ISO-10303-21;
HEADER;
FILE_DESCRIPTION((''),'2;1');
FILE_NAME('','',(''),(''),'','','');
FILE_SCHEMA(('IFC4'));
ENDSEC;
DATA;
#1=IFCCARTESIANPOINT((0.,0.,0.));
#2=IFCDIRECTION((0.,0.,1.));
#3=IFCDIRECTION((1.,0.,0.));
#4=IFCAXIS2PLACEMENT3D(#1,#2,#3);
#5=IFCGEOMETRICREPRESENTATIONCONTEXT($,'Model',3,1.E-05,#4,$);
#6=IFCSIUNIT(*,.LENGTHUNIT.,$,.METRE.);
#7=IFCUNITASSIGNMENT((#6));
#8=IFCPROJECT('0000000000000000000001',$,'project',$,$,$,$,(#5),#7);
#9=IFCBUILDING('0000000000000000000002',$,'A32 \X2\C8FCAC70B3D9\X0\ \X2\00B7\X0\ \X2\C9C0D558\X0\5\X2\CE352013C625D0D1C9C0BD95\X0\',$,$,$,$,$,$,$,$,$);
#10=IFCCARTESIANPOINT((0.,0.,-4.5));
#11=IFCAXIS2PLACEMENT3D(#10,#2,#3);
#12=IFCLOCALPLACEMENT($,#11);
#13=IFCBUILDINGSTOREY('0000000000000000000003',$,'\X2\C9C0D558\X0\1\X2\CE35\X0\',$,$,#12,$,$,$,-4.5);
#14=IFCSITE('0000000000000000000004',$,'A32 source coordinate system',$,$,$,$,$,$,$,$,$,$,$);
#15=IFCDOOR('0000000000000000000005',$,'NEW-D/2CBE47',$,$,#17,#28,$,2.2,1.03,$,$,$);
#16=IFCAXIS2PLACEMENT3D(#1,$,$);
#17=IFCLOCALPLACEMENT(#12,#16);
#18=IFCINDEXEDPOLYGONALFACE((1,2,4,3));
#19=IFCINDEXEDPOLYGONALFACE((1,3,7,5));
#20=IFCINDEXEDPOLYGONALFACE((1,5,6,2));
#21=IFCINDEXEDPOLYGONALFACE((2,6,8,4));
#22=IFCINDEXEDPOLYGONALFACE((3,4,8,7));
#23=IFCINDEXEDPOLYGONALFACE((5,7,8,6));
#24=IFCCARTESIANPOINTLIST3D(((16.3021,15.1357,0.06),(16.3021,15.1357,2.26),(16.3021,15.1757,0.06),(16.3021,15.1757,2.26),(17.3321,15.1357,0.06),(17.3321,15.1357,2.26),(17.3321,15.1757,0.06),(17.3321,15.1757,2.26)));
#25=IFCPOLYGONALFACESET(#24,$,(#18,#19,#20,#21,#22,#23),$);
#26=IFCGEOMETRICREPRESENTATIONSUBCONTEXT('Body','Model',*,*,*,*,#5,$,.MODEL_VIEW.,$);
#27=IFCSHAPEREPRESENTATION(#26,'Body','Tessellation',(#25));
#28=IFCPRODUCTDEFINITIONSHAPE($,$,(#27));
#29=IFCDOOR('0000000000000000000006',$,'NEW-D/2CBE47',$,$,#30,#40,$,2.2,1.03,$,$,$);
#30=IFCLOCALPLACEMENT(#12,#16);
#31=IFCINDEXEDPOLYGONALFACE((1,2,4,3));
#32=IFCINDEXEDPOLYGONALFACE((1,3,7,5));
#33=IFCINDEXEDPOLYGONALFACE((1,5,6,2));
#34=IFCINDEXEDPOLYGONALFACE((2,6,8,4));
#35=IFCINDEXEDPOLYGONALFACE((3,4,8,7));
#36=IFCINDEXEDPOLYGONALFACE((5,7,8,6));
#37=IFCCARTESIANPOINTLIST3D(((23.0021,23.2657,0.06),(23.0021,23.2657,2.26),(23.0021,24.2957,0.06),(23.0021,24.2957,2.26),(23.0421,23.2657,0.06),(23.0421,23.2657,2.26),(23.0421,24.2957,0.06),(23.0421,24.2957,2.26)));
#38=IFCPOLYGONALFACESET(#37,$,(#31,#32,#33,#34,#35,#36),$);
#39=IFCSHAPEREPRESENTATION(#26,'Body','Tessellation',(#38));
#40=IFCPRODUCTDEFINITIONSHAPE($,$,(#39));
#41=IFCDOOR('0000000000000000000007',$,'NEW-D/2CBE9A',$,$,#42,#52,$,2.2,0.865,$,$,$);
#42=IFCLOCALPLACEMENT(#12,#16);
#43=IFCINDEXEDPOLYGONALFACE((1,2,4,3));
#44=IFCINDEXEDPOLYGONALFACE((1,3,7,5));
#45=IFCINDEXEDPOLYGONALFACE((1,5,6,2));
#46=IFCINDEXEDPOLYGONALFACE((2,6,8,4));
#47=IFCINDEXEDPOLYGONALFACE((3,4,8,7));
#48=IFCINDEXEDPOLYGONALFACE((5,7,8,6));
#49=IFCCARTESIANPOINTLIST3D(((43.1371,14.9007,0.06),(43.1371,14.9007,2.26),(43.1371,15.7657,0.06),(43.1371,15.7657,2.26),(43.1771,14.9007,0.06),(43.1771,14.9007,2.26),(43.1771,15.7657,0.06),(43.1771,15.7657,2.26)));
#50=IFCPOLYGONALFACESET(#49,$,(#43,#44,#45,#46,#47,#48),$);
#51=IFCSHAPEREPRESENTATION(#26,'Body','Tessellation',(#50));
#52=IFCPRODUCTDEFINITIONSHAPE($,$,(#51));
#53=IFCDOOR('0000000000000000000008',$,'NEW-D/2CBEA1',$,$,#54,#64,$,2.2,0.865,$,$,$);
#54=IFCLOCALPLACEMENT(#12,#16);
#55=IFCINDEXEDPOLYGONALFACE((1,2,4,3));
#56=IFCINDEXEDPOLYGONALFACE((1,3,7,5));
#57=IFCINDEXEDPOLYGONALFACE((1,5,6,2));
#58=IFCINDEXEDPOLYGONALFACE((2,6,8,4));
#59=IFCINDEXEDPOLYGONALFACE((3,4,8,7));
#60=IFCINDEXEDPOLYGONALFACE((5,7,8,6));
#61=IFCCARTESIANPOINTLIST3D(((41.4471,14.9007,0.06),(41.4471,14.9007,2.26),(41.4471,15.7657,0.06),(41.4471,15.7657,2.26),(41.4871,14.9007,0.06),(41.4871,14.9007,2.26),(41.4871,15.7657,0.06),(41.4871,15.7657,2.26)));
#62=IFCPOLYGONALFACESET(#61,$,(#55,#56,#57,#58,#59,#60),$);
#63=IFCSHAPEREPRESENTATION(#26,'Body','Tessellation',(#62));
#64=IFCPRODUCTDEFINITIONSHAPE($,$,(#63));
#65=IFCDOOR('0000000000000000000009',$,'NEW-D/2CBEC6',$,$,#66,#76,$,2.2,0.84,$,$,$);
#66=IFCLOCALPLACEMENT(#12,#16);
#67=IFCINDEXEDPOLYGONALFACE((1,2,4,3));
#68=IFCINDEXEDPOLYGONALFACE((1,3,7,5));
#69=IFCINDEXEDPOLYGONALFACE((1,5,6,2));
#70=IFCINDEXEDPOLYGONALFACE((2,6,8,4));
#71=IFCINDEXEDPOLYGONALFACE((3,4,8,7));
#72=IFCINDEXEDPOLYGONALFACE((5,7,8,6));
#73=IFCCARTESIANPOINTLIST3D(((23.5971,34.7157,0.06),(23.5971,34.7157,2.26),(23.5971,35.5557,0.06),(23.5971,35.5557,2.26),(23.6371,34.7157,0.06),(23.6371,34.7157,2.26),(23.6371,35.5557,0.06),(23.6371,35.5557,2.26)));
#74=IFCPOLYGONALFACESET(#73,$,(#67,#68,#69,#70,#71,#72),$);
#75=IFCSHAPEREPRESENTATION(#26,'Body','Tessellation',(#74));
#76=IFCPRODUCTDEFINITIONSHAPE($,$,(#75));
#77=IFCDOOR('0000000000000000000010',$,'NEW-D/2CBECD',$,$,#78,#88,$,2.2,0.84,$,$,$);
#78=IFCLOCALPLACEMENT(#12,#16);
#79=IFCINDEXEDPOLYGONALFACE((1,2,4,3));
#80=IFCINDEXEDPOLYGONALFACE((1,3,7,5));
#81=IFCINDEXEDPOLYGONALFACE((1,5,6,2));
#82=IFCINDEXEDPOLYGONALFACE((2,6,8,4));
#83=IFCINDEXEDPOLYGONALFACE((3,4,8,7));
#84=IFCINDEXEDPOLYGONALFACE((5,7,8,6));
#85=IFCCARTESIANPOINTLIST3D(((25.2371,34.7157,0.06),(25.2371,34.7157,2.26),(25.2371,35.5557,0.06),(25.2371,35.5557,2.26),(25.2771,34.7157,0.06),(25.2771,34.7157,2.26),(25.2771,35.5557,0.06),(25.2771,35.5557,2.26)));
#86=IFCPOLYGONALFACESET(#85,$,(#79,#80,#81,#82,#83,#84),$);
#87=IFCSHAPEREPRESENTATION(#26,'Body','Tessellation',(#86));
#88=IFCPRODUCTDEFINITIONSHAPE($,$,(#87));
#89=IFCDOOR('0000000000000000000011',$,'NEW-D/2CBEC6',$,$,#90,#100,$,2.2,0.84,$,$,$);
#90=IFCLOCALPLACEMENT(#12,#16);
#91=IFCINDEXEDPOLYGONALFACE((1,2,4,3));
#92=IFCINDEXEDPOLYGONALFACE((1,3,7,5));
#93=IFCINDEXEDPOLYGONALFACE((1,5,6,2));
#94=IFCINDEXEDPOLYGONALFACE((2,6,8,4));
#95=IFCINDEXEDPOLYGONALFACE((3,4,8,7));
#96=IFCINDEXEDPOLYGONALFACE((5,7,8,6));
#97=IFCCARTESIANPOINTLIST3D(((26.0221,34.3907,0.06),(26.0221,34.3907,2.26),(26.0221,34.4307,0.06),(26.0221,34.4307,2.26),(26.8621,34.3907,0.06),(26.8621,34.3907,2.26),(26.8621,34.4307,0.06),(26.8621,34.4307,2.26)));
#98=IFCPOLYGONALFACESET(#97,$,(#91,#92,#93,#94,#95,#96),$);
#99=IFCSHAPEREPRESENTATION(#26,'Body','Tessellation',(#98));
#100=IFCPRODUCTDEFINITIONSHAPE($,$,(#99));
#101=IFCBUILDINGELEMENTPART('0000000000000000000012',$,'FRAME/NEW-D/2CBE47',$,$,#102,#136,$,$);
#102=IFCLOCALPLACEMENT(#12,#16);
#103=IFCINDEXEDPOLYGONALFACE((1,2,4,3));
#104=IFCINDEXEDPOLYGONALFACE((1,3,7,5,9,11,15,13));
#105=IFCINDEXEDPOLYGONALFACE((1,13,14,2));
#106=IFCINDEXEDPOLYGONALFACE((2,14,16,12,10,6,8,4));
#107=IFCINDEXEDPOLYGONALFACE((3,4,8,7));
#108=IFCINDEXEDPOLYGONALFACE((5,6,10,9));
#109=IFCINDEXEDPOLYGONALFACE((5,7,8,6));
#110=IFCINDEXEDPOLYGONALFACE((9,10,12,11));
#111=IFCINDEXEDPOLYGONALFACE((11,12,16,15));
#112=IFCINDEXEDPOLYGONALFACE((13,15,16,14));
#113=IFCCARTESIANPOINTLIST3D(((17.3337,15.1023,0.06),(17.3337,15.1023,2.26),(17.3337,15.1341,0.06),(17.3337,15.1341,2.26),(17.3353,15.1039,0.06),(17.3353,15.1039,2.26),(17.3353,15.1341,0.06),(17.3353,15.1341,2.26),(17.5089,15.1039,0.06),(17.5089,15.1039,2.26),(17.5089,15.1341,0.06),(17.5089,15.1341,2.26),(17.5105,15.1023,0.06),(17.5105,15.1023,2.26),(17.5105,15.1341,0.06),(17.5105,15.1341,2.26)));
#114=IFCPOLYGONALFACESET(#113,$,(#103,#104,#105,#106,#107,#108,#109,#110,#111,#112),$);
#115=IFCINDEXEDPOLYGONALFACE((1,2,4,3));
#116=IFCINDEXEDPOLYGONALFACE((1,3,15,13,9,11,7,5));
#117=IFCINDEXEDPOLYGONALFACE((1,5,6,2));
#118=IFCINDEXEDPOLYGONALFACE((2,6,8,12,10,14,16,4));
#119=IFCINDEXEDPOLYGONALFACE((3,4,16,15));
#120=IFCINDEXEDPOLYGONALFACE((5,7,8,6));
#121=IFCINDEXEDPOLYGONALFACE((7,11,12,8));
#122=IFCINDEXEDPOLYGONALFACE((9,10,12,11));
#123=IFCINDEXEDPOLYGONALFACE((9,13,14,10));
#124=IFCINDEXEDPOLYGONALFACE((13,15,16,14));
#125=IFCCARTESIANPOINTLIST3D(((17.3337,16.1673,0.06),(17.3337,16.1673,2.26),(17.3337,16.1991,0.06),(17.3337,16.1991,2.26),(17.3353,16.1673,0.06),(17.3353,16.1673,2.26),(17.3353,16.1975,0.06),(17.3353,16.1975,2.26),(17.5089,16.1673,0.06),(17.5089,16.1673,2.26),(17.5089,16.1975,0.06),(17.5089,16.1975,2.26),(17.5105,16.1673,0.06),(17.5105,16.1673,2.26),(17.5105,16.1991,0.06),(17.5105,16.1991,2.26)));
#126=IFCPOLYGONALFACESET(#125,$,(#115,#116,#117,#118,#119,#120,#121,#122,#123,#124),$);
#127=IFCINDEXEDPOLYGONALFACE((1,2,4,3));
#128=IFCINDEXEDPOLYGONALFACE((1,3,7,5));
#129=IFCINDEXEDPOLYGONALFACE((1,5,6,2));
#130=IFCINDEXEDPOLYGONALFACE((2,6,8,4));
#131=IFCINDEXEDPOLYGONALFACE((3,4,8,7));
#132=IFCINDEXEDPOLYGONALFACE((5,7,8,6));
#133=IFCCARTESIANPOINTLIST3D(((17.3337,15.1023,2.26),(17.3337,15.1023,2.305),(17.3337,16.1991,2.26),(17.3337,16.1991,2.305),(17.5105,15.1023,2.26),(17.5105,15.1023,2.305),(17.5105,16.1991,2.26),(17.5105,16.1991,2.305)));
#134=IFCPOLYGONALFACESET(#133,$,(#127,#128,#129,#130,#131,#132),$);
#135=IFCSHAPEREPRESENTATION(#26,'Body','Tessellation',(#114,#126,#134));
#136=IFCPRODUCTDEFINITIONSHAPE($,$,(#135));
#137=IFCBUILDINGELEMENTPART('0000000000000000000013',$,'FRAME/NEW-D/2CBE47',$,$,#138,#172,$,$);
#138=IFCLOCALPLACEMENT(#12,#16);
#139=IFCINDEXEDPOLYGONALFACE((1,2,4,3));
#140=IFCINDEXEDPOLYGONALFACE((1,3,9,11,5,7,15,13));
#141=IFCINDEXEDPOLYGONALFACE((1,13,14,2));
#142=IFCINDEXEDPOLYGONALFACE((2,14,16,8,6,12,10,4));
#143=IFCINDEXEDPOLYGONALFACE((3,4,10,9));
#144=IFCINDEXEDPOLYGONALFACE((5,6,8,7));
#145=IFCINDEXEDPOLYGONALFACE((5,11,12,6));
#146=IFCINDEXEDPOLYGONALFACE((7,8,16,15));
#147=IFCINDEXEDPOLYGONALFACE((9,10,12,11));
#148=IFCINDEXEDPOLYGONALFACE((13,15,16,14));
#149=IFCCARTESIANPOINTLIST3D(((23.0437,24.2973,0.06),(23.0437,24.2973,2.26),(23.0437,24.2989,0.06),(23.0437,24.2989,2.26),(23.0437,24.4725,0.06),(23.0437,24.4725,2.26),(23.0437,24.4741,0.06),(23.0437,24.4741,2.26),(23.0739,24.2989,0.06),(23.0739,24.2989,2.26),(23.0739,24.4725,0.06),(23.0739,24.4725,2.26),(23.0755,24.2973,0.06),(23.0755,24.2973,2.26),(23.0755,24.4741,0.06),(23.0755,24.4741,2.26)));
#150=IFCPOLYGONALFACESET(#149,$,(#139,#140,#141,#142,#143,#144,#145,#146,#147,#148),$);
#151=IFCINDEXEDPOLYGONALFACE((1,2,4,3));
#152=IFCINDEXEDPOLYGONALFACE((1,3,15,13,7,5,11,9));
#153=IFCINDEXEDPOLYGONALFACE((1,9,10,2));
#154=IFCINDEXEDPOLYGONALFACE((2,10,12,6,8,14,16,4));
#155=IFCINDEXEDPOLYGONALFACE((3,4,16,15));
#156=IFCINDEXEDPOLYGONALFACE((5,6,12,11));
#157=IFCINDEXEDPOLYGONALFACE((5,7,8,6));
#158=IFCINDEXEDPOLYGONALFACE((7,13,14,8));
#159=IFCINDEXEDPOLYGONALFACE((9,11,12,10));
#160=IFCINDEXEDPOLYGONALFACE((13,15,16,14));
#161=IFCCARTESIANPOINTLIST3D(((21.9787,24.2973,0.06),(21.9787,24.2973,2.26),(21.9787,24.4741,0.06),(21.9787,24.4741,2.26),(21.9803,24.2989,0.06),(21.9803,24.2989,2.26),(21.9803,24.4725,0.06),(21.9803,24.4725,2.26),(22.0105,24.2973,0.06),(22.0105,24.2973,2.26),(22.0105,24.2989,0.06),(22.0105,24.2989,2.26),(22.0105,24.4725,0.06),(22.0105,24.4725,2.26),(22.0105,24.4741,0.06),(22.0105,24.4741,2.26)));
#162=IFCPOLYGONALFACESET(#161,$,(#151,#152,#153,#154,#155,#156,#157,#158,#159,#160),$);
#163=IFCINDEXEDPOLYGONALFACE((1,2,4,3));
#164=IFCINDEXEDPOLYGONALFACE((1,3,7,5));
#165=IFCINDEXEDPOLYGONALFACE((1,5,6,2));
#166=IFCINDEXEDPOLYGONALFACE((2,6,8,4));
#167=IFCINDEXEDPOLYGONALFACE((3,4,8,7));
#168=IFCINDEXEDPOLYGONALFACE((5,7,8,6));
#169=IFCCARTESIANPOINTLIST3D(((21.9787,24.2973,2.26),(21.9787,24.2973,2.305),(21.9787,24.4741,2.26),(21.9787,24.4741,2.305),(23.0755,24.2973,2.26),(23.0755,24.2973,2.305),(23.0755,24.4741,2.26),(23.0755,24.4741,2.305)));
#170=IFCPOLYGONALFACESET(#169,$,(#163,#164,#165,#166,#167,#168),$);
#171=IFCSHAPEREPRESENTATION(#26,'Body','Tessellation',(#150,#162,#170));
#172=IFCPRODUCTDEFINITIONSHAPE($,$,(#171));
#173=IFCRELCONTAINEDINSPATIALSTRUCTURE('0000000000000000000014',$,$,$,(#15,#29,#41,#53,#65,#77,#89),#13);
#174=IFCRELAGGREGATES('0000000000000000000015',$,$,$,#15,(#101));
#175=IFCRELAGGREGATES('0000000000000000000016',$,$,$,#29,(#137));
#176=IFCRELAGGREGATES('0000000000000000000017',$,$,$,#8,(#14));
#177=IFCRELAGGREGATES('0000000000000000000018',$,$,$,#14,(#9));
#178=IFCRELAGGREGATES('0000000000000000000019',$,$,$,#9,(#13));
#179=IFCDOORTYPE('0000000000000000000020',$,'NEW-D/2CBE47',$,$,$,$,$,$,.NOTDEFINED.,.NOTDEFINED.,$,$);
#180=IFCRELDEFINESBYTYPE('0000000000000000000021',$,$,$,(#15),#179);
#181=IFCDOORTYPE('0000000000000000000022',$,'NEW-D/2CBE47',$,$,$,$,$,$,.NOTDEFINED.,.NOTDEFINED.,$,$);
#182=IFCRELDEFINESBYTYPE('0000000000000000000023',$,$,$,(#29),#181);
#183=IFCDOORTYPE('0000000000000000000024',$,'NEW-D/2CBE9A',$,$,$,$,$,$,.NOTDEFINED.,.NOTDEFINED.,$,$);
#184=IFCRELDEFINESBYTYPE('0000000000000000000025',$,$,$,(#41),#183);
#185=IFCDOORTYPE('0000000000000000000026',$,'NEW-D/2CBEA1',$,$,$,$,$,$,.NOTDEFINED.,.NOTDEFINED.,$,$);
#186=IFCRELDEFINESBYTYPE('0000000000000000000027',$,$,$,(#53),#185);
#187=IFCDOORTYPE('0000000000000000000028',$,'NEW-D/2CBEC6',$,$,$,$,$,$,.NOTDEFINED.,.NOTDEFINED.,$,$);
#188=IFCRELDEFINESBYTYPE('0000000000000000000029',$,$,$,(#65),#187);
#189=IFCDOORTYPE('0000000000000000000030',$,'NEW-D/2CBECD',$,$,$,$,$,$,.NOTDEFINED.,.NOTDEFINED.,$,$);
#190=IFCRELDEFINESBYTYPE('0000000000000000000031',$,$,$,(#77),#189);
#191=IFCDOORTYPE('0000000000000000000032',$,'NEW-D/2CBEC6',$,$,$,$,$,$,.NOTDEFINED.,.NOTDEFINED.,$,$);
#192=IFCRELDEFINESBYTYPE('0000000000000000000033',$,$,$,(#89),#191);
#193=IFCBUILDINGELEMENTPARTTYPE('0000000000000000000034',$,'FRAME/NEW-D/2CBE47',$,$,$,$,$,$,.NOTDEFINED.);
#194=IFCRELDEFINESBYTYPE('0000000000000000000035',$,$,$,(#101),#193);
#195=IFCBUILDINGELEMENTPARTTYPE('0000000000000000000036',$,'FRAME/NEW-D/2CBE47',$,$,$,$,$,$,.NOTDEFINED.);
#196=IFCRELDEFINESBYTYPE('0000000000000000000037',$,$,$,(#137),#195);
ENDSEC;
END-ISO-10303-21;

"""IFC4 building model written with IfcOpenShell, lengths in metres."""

from ifc_helpers import new_model, si_unit, frame, origin, origin_with_axes, place, context, subcontext, project, spatial, polyline, outline, extrude, source, transform, mapped, type_object, type_shapes, element, aggregate, save


model = new_model("IFC4")

# Units and contexts
model_context = context("Model", 3, precision=1e-05, world=origin_with_axes())
body_context = subcontext(model_context, "Body", "Model", "MODEL_VIEW")
ifc_project = project(units=[si_unit("LENGTHUNIT", "METRE")], contexts=[model_context])

# Site, building, storey
storey_placement = place(None, frame((0.0, 0.0, -4.5), z_axis=(0.0, 0.0, 1.0), x_axis=(1.0, 0.0, 0.0)))
site = spatial("IfcSite", under=ifc_project, Name="A32 source coordinate system")
building = spatial("IfcBuilding", under=site, Name="A32 주거동 · 지하5층–옥탑지붕")
storey = spatial("IfcBuildingStorey", under=building, at=storey_placement, Name="지하1층", Elevation=-4.5)

# Doors
door_type_1 = type_object("IfcDoorType", Name="NEW-D/2CBE47", OperationType="NOTDEFINED", PredefinedType="NOTDEFINED")
shared_shape_1 = source(origin(), body_context, "Body", "SweptSolid", [
    extrude(outline(polyline([(16.3021, 15.1757), (17.3321, 15.1757), (17.3321, 15.1357), (16.3021, 15.1357), (16.3021, 15.1757)])), frame((0.0, 0.0, 0.06)), (0.0, 0.0, 1.0), 2.2),
])
type_shapes(door_type_1, [shared_shape_1])
door_1_placement = place(storey_placement, origin_with_axes())
door_1 = element("IfcDoor", 1, at=door_1_placement, inside=storey, type_object=door_type_1, Name="NEW-D/2CBE47", OverallHeight=2.2, OverallWidth=1.03, context=body_context, shape_type="MappedRepresentation", body=[
    mapped(shared_shape_1, transform((0.0, 0.0, 0.0), scale=1.0)),
])
door_type_2 = type_object("IfcDoorType", Name="NEW-D/2CBE47", OperationType="NOTDEFINED", PredefinedType="NOTDEFINED")
shared_shape_2 = source(origin(), body_context, "Body", "SweptSolid", [
    extrude(outline(polyline([(23.0021, 23.2657), (23.0021, 24.2957), (23.0421, 24.2957), (23.0421, 23.2657), (23.0021, 23.2657)])), frame((0.0, 0.0, 0.06)), (0.0, 0.0, 1.0), 2.2),
])
type_shapes(door_type_2, [shared_shape_2])
door_2_placement = place(storey_placement, origin_with_axes())
door_2 = element("IfcDoor", 2, at=door_2_placement, inside=storey, type_object=door_type_2, Name="NEW-D/2CBE47", OverallHeight=2.2, OverallWidth=1.03, context=body_context, shape_type="MappedRepresentation", body=[
    mapped(shared_shape_2, transform((0.0, 0.0, 0.0), scale=1.0)),
])

# Doors
door_type_3 = type_object("IfcDoorType", Name="NEW-D/2CBE9A", OperationType="NOTDEFINED", PredefinedType="NOTDEFINED")
shared_shape_3 = source(origin(), body_context, "Body", "SweptSolid", [
    extrude(outline(polyline([(43.1771, 15.7657), (43.1771, 14.9007), (43.1371, 14.9007), (43.1371, 15.7657), (43.1771, 15.7657)])), frame((0.0, 0.0, 0.06)), (0.0, 0.0, 1.0), 2.2),
])
type_shapes(door_type_3, [shared_shape_3])
door_3_placement = place(storey_placement, origin_with_axes())
element("IfcDoor", 3, at=door_3_placement, inside=storey, type_object=door_type_3, Name="NEW-D/2CBE9A", OverallHeight=2.2, OverallWidth=0.865, context=body_context, shape_type="MappedRepresentation", body=[
    mapped(shared_shape_3, transform((0.0, 0.0, 0.0), scale=1.0)),
])
door_type_4 = type_object("IfcDoorType", Name="NEW-D/2CBEA1", OperationType="NOTDEFINED", PredefinedType="NOTDEFINED")
shared_shape_4 = source(origin(), body_context, "Body", "SweptSolid", [
    extrude(outline(polyline([(41.4871, 14.9007), (41.4471, 14.9007), (41.4471, 15.7657), (41.4871, 15.7657), (41.4871, 14.9007)])), frame((0.0, 0.0, 0.06)), (0.0, 0.0, 1.0), 2.2),
])
type_shapes(door_type_4, [shared_shape_4])
door_4_placement = place(storey_placement, origin_with_axes())
element("IfcDoor", 4, at=door_4_placement, inside=storey, type_object=door_type_4, Name="NEW-D/2CBEA1", OverallHeight=2.2, OverallWidth=0.865, context=body_context, shape_type="MappedRepresentation", body=[
    mapped(shared_shape_4, transform((0.0, 0.0, 0.0), scale=1.0)),
])
door_type_5 = type_object("IfcDoorType", Name="NEW-D/2CBEC6", OperationType="NOTDEFINED", PredefinedType="NOTDEFINED")
shared_shape_5 = source(origin(), body_context, "Body", "SweptSolid", [
    extrude(outline(polyline([(23.6371, 34.7157), (23.5971, 34.7157), (23.5971, 35.5557), (23.6371, 35.5557), (23.6371, 34.7157)])), frame((0.0, 0.0, 0.06)), (0.0, 0.0, 1.0), 2.2),
])
type_shapes(door_type_5, [shared_shape_5])
door_5_placement = place(storey_placement, origin_with_axes())
element("IfcDoor", 5, at=door_5_placement, inside=storey, type_object=door_type_5, Name="NEW-D/2CBEC6", OverallHeight=2.2, OverallWidth=0.84, context=body_context, shape_type="MappedRepresentation", body=[
    mapped(shared_shape_5, transform((0.0, 0.0, 0.0), scale=1.0)),
])
door_type_6 = type_object("IfcDoorType", Name="NEW-D/2CBECD", OperationType="NOTDEFINED", PredefinedType="NOTDEFINED")
shared_shape_6 = source(origin(), body_context, "Body", "SweptSolid", [
    extrude(outline(polyline([(25.2771, 35.5557), (25.2771, 34.7157), (25.2371, 34.7157), (25.2371, 35.5557), (25.2771, 35.5557)])), frame((0.0, 0.0, 0.06)), (0.0, 0.0, 1.0), 2.2),
])
type_shapes(door_type_6, [shared_shape_6])
door_6_placement = place(storey_placement, origin_with_axes())
element("IfcDoor", 6, at=door_6_placement, inside=storey, type_object=door_type_6, Name="NEW-D/2CBECD", OverallHeight=2.2, OverallWidth=0.84, context=body_context, shape_type="MappedRepresentation", body=[
    mapped(shared_shape_6, transform((0.0, 0.0, 0.0), scale=1.0)),
])
door_type_7 = type_object("IfcDoorType", Name="NEW-D/2CBEC6", OperationType="NOTDEFINED", PredefinedType="NOTDEFINED")
shared_shape_7 = source(origin(), body_context, "Body", "SweptSolid", [
    extrude(outline(polyline([(26.0221, 34.3907), (26.0221, 34.4307), (26.8621, 34.4307), (26.8621, 34.3907), (26.0221, 34.3907)])), frame((0.0, 0.0, 0.06)), (0.0, 0.0, 1.0), 2.2),
])
type_shapes(door_type_7, [shared_shape_7])
door_7_placement = place(storey_placement, origin_with_axes())
element("IfcDoor", 7, at=door_7_placement, inside=storey, type_object=door_type_7, Name="NEW-D/2CBEC6", OverallHeight=2.2, OverallWidth=0.84, context=body_context, shape_type="MappedRepresentation", body=[
    mapped(shared_shape_7, transform((0.0, 0.0, 0.0), scale=1.0)),
])

# Building element parts
building_element_part_type_1 = type_object("IfcBuildingElementPartType", Name="FRAME/NEW-D/2CBE47", PredefinedType="NOTDEFINED")
shared_shape_8 = source(origin(), body_context, "Body", "SweptSolid", [
    extrude(outline(polyline([(17.3353, 15.1039), (17.5089, 15.1039), (17.5089, 15.1341), (17.5105, 15.1341), (17.5105, 15.1023), (17.3337, 15.1023), (17.3337, 15.1341), (17.3353, 15.1341), (17.3353, 15.1039)])), frame((0.0, 0.0, 0.06)), (0.0, 0.0, 1.0), 2.2),
    extrude(outline(polyline([(17.5105, 16.1991), (17.5105, 16.1673), (17.5089, 16.1673), (17.5089, 16.1975), (17.3353, 16.1975), (17.3353, 16.1673), (17.3337, 16.1673), (17.3337, 16.1991), (17.5105, 16.1991)])), frame((0.0, 0.0, 0.06)), (0.0, 0.0, 1.0), 2.2),
    extrude(outline(polyline([(17.5105, 15.1023), (17.5105, 16.1991), (17.3337, 16.1991), (17.3337, 15.1023), (17.5105, 15.1023)])), frame((0.0, 0.0, 2.26)), (0.0, 0.0, 1.0), 0.045),
])
type_shapes(building_element_part_type_1, [shared_shape_8])
building_element_part_1_placement = place(door_1_placement, origin_with_axes())
building_element_part_1 = element("IfcBuildingElementPart", 8, at=building_element_part_1_placement, type_object=building_element_part_type_1, Name="FRAME/NEW-D/2CBE47", context=body_context, shape_type="MappedRepresentation", body=[
    mapped(shared_shape_8, transform((0.0, 0.0, 0.0), scale=1.0)),
])
aggregate(door_1, [building_element_part_1])
building_element_part_type_2 = type_object("IfcBuildingElementPartType", Name="FRAME/NEW-D/2CBE47", PredefinedType="NOTDEFINED")
shared_shape_9 = source(origin(), body_context, "Body", "SweptSolid", [
    extrude(outline(polyline([(23.0739, 24.2989), (23.0739, 24.4725), (23.0437, 24.4725), (23.0437, 24.4741), (23.0755, 24.4741), (23.0755, 24.2973), (23.0437, 24.2973), (23.0437, 24.2989), (23.0739, 24.2989)])), frame((0.0, 0.0, 0.06)), (0.0, 0.0, 1.0), 2.2),
    extrude(outline(polyline([(21.9787, 24.4741), (22.0105, 24.4741), (22.0105, 24.4725), (21.9803, 24.4725), (21.9803, 24.2989), (22.0105, 24.2989), (22.0105, 24.2973), (21.9787, 24.2973), (21.9787, 24.4741)])), frame((0.0, 0.0, 0.06)), (0.0, 0.0, 1.0), 2.2),
    extrude(outline(polyline([(23.0755, 24.2973), (23.0755, 24.4741), (21.9787, 24.4741), (21.9787, 24.2973), (23.0755, 24.2973)])), frame((0.0, 0.0, 2.26)), (0.0, 0.0, 1.0), 0.045),
])
type_shapes(building_element_part_type_2, [shared_shape_9])
building_element_part_2_placement = place(door_2_placement, origin_with_axes())
building_element_part_2 = element("IfcBuildingElementPart", 9, at=building_element_part_2_placement, type_object=building_element_part_type_2, Name="FRAME/NEW-D/2CBE47", context=body_context, shape_type="MappedRepresentation", body=[
    mapped(shared_shape_9, transform((0.0, 0.0, 0.0), scale=1.0)),
])
aggregate(door_2, [building_element_part_2])

save(model, "model.ifc")
